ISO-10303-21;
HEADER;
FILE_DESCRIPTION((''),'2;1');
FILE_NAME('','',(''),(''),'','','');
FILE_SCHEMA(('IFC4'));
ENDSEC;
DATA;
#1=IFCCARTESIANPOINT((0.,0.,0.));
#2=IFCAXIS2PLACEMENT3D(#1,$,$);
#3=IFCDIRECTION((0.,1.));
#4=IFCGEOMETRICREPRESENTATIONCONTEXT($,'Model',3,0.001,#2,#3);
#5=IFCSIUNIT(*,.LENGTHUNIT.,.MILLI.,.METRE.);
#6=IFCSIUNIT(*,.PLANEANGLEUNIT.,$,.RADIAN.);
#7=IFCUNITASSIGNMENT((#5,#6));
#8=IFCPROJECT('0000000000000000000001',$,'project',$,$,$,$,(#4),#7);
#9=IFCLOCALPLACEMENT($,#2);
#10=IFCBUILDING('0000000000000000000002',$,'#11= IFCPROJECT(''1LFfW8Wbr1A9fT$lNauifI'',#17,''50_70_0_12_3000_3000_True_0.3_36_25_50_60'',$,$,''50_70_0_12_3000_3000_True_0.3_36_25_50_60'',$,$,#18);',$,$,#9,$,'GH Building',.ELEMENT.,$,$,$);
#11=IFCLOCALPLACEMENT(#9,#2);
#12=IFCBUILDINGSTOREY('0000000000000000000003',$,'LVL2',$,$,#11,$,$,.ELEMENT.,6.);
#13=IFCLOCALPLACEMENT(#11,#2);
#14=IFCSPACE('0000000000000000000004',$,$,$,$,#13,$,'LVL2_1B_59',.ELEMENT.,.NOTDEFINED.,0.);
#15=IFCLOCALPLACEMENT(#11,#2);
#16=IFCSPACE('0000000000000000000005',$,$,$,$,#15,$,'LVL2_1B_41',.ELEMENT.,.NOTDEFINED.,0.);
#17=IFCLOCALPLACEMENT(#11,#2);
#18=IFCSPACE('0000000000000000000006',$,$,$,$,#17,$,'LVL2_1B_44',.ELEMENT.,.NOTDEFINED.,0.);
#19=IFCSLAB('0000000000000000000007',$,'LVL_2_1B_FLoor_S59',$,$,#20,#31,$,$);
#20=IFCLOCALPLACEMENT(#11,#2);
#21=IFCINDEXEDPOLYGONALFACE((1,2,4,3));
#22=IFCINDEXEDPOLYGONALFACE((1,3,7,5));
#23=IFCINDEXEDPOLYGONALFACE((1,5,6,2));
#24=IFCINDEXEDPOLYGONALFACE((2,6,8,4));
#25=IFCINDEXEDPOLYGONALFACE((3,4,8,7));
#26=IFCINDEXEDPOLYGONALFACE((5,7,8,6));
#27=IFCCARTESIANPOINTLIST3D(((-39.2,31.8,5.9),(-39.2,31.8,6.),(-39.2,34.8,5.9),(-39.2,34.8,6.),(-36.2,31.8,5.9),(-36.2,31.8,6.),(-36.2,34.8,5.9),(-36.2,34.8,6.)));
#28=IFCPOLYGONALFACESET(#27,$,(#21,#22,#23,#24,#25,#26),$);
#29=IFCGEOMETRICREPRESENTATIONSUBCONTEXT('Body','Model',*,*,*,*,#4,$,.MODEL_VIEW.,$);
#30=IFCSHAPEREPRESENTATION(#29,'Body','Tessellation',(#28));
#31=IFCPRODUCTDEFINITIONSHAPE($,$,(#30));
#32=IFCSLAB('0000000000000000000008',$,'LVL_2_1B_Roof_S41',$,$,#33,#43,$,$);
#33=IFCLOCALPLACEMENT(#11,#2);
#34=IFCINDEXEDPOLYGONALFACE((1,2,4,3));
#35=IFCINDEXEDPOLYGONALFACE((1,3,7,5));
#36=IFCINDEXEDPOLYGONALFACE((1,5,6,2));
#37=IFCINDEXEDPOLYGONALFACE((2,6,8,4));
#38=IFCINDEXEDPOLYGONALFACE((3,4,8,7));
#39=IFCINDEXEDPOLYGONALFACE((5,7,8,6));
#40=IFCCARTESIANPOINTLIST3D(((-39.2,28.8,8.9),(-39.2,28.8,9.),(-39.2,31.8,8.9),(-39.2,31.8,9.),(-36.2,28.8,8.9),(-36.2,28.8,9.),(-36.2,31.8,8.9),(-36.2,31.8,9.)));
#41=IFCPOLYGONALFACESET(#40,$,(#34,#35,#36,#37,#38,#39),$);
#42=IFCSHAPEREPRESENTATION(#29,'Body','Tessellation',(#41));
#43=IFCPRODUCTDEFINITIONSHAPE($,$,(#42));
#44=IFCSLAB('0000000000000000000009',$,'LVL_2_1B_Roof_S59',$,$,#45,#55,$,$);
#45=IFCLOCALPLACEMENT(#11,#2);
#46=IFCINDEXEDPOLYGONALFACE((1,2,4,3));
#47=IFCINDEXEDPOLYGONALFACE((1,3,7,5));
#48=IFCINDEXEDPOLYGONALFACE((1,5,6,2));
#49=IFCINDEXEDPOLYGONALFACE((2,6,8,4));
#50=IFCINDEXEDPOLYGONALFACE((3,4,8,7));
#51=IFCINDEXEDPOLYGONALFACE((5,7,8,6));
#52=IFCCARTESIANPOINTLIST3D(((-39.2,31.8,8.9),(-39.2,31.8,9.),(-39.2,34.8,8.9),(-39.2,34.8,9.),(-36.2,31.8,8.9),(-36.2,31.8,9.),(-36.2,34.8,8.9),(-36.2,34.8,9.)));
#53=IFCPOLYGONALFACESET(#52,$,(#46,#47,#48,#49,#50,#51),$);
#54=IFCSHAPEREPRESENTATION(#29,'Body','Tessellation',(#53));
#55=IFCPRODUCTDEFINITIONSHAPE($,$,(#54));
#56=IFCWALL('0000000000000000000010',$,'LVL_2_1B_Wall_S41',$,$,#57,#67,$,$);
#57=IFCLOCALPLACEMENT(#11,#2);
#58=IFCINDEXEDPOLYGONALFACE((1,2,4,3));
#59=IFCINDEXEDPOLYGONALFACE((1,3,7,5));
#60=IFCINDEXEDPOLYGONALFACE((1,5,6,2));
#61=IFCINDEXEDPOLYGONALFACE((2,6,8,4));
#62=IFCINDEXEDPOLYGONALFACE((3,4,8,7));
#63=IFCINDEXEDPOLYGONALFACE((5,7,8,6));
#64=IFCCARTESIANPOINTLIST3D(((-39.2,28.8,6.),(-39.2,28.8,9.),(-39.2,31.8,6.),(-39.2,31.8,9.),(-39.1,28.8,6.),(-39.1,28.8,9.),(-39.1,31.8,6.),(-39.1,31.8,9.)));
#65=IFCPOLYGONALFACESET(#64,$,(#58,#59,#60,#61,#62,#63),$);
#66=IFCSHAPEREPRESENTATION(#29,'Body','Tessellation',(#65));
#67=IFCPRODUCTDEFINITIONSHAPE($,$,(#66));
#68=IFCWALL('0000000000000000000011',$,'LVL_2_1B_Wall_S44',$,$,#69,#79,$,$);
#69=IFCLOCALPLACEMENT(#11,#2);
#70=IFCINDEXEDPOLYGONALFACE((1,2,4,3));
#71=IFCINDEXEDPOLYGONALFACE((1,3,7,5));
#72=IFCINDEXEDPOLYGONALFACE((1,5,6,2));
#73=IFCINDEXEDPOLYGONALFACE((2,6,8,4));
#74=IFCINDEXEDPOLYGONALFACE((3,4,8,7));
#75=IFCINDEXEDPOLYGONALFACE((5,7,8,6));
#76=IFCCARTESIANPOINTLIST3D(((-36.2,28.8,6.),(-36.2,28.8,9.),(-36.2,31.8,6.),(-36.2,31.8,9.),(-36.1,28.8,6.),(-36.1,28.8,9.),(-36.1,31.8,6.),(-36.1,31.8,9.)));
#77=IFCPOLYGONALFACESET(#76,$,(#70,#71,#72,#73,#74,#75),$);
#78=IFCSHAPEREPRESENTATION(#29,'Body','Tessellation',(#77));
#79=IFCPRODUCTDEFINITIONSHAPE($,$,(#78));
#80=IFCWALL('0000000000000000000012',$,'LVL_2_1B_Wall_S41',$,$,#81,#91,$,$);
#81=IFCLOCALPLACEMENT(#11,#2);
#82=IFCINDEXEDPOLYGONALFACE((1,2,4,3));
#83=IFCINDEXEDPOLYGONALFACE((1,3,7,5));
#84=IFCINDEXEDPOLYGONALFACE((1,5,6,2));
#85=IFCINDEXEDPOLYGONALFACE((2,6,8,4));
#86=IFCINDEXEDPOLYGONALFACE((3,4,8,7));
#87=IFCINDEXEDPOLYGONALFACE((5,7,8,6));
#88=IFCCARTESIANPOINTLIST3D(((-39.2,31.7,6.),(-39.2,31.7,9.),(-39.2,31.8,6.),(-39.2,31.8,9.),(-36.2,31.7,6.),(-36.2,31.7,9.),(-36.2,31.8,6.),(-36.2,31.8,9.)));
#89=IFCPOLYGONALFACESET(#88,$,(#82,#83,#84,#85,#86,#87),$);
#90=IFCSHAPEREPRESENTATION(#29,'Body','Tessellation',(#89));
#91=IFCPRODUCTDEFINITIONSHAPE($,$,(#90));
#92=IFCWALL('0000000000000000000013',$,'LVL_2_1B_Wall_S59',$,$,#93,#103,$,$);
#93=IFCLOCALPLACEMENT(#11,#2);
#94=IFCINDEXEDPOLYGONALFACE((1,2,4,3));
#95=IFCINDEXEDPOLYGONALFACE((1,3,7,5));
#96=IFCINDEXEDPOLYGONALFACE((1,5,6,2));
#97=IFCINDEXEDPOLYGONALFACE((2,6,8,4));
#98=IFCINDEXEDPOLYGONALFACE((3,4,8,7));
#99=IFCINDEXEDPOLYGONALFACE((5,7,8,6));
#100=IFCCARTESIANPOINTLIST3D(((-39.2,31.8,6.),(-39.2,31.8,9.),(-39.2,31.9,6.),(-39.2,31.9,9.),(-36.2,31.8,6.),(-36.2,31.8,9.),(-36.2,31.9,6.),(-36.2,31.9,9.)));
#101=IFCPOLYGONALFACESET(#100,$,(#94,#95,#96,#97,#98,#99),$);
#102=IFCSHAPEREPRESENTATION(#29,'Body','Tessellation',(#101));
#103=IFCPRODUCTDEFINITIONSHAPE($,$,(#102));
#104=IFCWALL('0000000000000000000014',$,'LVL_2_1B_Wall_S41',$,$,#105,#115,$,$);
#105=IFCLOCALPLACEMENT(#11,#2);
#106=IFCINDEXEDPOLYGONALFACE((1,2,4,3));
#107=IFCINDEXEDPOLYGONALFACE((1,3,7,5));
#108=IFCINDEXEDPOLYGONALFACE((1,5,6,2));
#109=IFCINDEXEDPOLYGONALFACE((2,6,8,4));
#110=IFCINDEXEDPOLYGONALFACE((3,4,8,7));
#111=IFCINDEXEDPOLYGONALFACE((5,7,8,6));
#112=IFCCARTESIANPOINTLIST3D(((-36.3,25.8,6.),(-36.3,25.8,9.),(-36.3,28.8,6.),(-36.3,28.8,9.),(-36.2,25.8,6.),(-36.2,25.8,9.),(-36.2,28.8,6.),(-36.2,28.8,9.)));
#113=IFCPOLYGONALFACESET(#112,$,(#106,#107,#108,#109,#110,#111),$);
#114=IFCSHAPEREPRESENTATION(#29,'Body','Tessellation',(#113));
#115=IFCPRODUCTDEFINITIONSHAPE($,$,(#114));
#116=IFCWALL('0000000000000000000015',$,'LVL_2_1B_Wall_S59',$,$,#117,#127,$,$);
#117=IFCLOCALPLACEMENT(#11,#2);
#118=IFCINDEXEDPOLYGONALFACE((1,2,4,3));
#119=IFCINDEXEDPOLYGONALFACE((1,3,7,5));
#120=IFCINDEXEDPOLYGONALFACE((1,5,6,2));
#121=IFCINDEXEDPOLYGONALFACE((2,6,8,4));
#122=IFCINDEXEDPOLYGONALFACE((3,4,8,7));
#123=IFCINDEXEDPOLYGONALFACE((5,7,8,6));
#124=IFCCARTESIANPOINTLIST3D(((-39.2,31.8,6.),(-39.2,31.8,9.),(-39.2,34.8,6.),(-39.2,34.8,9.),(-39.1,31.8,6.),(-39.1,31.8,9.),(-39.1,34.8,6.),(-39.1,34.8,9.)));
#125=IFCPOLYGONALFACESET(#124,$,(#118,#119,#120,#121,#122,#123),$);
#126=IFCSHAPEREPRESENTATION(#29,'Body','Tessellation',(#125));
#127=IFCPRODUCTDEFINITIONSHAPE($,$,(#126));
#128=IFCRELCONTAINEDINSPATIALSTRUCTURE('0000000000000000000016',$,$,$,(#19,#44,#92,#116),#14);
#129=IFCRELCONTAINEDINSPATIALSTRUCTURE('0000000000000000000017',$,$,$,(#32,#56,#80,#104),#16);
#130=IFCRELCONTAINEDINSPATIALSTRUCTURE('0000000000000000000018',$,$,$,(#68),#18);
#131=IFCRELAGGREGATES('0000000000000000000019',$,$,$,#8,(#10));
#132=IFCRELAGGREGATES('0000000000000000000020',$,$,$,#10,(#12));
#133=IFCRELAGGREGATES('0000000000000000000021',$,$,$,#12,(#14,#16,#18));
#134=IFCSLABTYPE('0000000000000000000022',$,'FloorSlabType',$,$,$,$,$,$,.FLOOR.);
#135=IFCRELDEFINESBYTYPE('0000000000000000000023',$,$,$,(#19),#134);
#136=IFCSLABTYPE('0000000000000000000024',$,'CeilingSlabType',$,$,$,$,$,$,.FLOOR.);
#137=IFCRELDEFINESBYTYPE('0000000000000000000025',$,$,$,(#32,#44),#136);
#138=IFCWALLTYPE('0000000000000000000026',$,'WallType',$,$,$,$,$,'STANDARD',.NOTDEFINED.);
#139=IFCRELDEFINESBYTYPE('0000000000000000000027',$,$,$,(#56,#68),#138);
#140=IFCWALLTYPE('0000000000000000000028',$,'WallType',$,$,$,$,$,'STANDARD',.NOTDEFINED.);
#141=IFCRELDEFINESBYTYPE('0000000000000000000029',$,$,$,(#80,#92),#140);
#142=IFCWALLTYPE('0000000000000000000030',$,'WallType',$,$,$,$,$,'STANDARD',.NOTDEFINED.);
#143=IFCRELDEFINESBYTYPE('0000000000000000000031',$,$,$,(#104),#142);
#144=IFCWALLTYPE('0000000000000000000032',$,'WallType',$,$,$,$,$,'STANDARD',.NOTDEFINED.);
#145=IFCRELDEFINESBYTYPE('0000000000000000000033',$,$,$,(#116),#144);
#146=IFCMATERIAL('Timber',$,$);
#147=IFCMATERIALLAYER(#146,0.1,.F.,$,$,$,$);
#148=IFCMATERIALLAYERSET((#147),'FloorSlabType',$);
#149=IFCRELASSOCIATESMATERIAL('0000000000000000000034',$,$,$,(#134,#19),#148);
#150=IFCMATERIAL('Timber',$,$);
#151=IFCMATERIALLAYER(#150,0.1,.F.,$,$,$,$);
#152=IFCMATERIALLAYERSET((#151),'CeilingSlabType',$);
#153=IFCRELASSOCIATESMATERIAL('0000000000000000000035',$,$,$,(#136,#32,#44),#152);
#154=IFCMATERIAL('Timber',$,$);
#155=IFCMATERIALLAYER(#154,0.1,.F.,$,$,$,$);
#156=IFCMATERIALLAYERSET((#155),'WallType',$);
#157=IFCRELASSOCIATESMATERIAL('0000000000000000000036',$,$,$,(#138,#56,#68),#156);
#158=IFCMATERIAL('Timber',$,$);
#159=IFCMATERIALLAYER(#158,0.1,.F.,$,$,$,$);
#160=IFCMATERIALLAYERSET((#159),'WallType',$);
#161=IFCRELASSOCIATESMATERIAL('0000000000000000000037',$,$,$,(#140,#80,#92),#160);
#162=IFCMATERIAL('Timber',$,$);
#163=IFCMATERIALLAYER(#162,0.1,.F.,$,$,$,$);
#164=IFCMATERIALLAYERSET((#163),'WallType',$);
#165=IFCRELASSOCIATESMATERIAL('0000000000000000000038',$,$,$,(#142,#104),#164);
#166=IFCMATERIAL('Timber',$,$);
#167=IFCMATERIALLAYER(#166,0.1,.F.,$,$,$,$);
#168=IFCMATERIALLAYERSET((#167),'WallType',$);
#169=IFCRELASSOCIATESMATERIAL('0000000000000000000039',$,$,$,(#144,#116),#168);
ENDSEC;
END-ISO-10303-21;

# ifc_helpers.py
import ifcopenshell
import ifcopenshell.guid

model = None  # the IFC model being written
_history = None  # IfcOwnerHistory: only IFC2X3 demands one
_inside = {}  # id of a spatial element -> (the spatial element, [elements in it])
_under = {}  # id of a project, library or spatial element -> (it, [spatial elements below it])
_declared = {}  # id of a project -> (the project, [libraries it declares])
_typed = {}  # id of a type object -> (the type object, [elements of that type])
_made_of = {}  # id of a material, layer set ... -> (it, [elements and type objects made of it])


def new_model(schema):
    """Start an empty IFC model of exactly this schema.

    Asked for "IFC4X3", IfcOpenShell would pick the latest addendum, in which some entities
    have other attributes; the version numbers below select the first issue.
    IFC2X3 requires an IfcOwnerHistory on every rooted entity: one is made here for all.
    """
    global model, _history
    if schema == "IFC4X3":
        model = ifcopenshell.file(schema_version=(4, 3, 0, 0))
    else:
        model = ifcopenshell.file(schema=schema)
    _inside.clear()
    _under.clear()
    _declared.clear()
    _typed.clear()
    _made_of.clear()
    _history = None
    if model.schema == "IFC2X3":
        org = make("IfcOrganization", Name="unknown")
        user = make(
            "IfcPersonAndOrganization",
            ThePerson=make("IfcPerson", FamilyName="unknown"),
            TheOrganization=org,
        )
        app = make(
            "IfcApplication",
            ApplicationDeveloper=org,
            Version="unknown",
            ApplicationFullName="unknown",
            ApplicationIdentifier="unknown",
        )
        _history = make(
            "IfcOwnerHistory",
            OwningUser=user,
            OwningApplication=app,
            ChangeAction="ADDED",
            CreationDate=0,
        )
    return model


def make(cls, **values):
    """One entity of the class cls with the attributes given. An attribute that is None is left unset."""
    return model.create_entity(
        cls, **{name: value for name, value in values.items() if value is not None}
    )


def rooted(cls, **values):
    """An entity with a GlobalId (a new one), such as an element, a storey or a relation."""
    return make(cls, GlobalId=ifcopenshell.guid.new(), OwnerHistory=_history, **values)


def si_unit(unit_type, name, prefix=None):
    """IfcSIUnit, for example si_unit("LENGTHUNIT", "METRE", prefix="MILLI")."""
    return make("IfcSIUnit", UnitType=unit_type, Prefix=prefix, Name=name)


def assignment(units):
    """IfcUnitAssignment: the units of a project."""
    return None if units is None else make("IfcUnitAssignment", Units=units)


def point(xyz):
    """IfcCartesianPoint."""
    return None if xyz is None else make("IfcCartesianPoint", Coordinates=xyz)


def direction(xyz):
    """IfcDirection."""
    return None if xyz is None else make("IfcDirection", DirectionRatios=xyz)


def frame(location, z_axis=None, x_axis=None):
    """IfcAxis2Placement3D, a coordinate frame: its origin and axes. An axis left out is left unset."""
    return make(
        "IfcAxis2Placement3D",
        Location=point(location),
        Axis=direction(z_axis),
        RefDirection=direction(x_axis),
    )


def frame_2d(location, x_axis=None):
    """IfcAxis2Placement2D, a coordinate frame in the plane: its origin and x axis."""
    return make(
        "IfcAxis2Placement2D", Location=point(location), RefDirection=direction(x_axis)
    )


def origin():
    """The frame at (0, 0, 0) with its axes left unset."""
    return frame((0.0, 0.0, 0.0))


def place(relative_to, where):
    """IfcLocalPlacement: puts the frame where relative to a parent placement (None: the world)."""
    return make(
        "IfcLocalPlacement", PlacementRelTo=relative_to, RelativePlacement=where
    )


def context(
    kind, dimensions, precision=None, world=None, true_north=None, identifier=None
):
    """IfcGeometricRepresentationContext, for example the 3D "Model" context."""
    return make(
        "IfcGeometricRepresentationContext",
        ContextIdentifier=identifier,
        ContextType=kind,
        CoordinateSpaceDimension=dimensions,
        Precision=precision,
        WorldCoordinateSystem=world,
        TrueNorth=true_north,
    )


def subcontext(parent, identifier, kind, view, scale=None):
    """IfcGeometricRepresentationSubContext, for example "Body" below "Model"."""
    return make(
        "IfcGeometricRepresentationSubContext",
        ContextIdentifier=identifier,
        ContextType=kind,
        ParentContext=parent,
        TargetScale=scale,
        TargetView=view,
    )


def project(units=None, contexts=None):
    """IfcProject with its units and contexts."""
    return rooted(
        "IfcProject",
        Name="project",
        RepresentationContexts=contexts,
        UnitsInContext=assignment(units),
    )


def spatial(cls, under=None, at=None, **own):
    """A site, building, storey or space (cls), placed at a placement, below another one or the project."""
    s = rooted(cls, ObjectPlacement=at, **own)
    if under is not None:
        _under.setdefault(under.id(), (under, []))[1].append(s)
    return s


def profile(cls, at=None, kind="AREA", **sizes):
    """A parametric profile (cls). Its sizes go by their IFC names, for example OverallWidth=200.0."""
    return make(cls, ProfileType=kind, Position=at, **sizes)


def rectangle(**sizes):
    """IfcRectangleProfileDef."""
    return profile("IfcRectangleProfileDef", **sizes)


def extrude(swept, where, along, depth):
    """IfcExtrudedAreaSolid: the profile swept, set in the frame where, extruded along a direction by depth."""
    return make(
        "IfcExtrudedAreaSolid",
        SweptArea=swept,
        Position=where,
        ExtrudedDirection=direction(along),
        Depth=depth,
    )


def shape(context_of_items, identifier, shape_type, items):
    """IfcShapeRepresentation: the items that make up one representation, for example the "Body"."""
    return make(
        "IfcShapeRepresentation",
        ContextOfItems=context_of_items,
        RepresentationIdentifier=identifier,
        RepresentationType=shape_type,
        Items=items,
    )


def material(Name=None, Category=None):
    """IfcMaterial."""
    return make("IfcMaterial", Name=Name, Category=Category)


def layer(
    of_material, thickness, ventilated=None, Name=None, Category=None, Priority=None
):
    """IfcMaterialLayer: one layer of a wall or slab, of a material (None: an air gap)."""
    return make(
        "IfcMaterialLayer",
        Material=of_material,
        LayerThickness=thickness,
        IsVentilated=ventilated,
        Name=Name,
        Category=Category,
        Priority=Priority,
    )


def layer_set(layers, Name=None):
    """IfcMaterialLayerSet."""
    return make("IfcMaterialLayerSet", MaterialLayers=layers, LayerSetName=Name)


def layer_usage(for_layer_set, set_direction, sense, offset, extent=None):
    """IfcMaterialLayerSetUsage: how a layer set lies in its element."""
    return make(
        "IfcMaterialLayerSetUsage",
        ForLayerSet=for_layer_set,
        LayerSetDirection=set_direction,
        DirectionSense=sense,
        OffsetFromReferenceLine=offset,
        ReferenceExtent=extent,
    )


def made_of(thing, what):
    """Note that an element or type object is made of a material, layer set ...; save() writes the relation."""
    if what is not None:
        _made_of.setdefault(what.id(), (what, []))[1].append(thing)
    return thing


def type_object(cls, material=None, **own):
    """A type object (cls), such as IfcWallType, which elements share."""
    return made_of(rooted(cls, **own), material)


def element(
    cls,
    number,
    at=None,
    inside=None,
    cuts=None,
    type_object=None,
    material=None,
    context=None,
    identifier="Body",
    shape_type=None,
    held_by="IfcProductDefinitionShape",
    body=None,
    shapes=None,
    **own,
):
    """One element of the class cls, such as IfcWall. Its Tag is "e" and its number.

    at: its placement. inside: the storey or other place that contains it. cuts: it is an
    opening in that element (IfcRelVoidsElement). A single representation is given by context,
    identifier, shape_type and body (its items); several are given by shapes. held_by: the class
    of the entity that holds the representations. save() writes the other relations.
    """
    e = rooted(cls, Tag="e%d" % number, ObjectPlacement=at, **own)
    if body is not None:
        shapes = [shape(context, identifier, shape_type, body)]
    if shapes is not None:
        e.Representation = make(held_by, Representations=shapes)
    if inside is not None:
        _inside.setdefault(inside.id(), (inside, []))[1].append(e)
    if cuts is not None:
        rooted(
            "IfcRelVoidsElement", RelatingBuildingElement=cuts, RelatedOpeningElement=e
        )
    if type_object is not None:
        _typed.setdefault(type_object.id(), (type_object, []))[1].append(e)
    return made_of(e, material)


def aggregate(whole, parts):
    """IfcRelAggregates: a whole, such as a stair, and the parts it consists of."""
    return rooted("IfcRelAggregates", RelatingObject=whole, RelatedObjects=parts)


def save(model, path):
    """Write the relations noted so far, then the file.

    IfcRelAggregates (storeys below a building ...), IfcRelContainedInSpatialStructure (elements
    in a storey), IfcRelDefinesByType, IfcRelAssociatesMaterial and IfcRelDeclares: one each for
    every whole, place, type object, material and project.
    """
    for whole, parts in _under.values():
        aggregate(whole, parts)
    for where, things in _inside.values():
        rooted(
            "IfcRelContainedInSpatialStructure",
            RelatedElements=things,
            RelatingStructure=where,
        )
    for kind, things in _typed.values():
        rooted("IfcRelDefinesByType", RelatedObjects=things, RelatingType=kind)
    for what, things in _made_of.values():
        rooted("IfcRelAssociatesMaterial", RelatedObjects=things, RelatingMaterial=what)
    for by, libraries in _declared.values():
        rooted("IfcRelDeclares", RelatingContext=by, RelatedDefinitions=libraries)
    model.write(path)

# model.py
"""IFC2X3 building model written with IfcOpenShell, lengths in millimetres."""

from ifc_helpers import new_model, si_unit, direction, frame, frame_2d, origin, place, context, subcontext, project, spatial, rectangle, extrude, material, layer, layer_set, layer_usage, type_object, element, save


model = new_model("IFC2X3")

# Units and contexts
model_context = context("Model", 3, precision=0.001, world=origin(), true_north=direction((0.0, 1.0)))
body_context = subcontext(model_context, "Body", "Model", "MODEL_VIEW")
ifc_project = project(units=[si_unit("LENGTHUNIT", "METRE", prefix="MILLI"), si_unit("PLANEANGLEUNIT", "RADIAN")], contexts=[model_context])

# Building, storey
building_placement = place(None, origin())
building = spatial("IfcBuilding", under=ifc_project, at=building_placement, Name="#11= IFCPROJECT('1LFfW8Wbr1A9fT$lNauifI',#17,'50_70_0_12_3000_3000_True_0.3_36_25_50_60',$,$,'50_70_0_12_3000_3000_True_0.3_36_25_50_60',$,$,#18);", LongName="GH Building", CompositionType="ELEMENT")
storey_placement = place(building_placement, origin())
storey = spatial("IfcBuildingStorey", under=building, at=storey_placement, Name="LVL2", CompositionType="ELEMENT", Elevation=6.0)

# Shared definitions
space_1_placement = place(storey_placement, origin())
space_1 = spatial("IfcSpace", under=storey, at=space_1_placement, LongName="LVL2_1B_59", CompositionType="ELEMENT", InteriorOrExteriorSpace="NOTDEFINED", ElevationWithFlooring=0.0)

# Slab
ifc_material_1 = material(Name="Timber")
ifc_layer_1 = layer(ifc_material_1, 0.1, ventilated=False)
ifc_layer_set_1 = layer_set([ifc_layer_1], Name="FloorSlabType")
ifc_layer_usage_1 = layer_usage(ifc_layer_set_1, "AXIS3", "NEGATIVE", -0.1)
slab_type_1 = type_object("IfcSlabType", Name="FloorSlabType", PredefinedType="FLOOR", material=ifc_layer_set_1)
slab_1_placement = place(space_1_placement, frame((-39.2, 34.8, 5.9), z_axis=(0.0, 0.0, 1.0), x_axis=(0.0, -1.0, 0.0)))
element("IfcSlab", 1, at=slab_1_placement, inside=space_1, type_object=slab_type_1, material=ifc_layer_usage_1, Name="LVL_2_1B_FLoor_S59", context=body_context, shape_type="SweptSolid", body=[
    extrude(rectangle(XDim=3.0, YDim=3.0, at=frame_2d((1.5, 1.5))), origin(), (0.0, 0.0, 1.0), 0.1),
])

# Shared definitions
space_2_placement = place(storey_placement, origin())
space_2 = spatial("IfcSpace", under=storey, at=space_2_placement, LongName="LVL2_1B_41", CompositionType="ELEMENT", InteriorOrExteriorSpace="NOTDEFINED", ElevationWithFlooring=0.0)

# Slabs
ifc_material_2 = material(Name="Timber")
ifc_layer_2 = layer(ifc_material_2, 0.1, ventilated=False)
ifc_layer_set_2 = layer_set([ifc_layer_2], Name="CeilingSlabType")
ifc_layer_usage_2 = layer_usage(ifc_layer_set_2, "AXIS3", "NEGATIVE", -0.1)
slab_type_2 = type_object("IfcSlabType", Name="CeilingSlabType", PredefinedType="FLOOR", material=ifc_layer_set_2)
slab_2_placement = place(space_2_placement, frame((-36.2, 28.8, 8.9), z_axis=(0.0, 0.0, 1.0), x_axis=(0.0, 1.0, 0.0)))
element("IfcSlab", 2, at=slab_2_placement, inside=space_2, type_object=slab_type_2, material=ifc_layer_usage_2, Name="LVL_2_1B_Roof_S41", context=body_context, shape_type="SweptSolid", body=[
    extrude(rectangle(XDim=3.0, YDim=3.0, at=frame_2d((1.5, 1.5))), origin(), (0.0, 0.0, 1.0), 0.1),
])
ifc_layer_usage_3 = layer_usage(ifc_layer_set_2, "AXIS3", "NEGATIVE", -0.1)
slab_3_placement = place(space_1_placement, frame((-39.2, 34.8, 8.9), z_axis=(0.0, 0.0, 1.0), x_axis=(0.0, -1.0, 0.0)))
element("IfcSlab", 3, at=slab_3_placement, inside=space_1, type_object=slab_type_2, material=ifc_layer_usage_3, Name="LVL_2_1B_Roof_S59", context=body_context, shape_type="SweptSolid", body=[
    extrude(rectangle(XDim=3.0, YDim=3.0, at=frame_2d((1.5, 1.5))), origin(), (0.0, 0.0, 1.0), 0.1),
])

# Shared definitions
space_3_placement = place(storey_placement, origin())
space_3 = spatial("IfcSpace", under=storey, at=space_3_placement, LongName="LVL2_1B_44", CompositionType="ELEMENT", InteriorOrExteriorSpace="NOTDEFINED", ElevationWithFlooring=0.0)

# Walls
ifc_material_3 = material(Name="Timber")
ifc_layer_3 = layer(ifc_material_3, 0.1, ventilated=False)
ifc_layer_set_3 = layer_set([ifc_layer_3], Name="WallType")
ifc_layer_usage_4 = layer_usage(ifc_layer_set_3, "AXIS2", "NEGATIVE", 0.0)
wall_type_1 = type_object("IfcWallType", Name="WallType", ElementType="STANDARD", PredefinedType="NOTDEFINED", material=ifc_layer_set_3)
wall_1_placement = place(space_2_placement, frame((-39.2, 28.8, 6.0), z_axis=(0.0, 0.0, 1.0), x_axis=(0.0, 1.0, 0.0)))
element("IfcWall", 4, at=wall_1_placement, inside=space_2, type_object=wall_type_1, material=ifc_layer_usage_4, Name="LVL_2_1B_Wall_S41", context=body_context, shape_type="SweptSolid", body=[
    extrude(rectangle(XDim=3.0, YDim=0.1, at=frame_2d((1.5, -0.1))), origin(), (0.0, 0.0, 1.0), 3.0),
])
ifc_layer_usage_5 = layer_usage(ifc_layer_set_3, "AXIS2", "NEGATIVE", 0.0)
wall_2_placement = place(space_3_placement, frame((-36.2, 28.8, 6.0), z_axis=(0.0, 0.0, 1.0), x_axis=(0.0, 1.0, 0.0)))
element("IfcWall", 5, at=wall_2_placement, inside=space_3, type_object=wall_type_1, material=ifc_layer_usage_5, Name="LVL_2_1B_Wall_S44", context=body_context, shape_type="SweptSolid", body=[
    extrude(rectangle(XDim=3.0, YDim=0.1, at=frame_2d((1.5, -0.1))), origin(), (0.0, 0.0, 1.0), 3.0),
])
ifc_material_4 = material(Name="Timber")
ifc_layer_4 = layer(ifc_material_4, 0.1, ventilated=False)
ifc_layer_set_4 = layer_set([ifc_layer_4], Name="WallType")
ifc_layer_usage_6 = layer_usage(ifc_layer_set_4, "AXIS2", "NEGATIVE", 0.0)
wall_type_2 = type_object("IfcWallType", Name="WallType", ElementType="STANDARD", PredefinedType="NOTDEFINED", material=ifc_layer_set_4)
wall_3_placement = place(space_2_placement, frame((-39.2, 31.8, 6.0)))
element("IfcWall", 6, at=wall_3_placement, inside=space_2, type_object=wall_type_2, material=ifc_layer_usage_6, Name="LVL_2_1B_Wall_S41", context=body_context, shape_type="SweptSolid", body=[
    extrude(rectangle(XDim=3.0, YDim=0.1, at=frame_2d((1.5, -0.1))), origin(), (0.0, 0.0, 1.0), 3.0),
])
ifc_layer_usage_7 = layer_usage(ifc_layer_set_4, "AXIS2", "NEGATIVE", 0.0)
wall_4_placement = place(space_1_placement, frame((-36.2, 31.8, 6.0), z_axis=(0.0, 0.0, 1.0), x_axis=(-1.0, 0.0, 0.0)))
element("IfcWall", 7, at=wall_4_placement, inside=space_1, type_object=wall_type_2, material=ifc_layer_usage_7, Name="LVL_2_1B_Wall_S59", context=body_context, shape_type="SweptSolid", body=[
    extrude(rectangle(XDim=3.0, YDim=0.1, at=frame_2d((1.5, -0.1))), origin(), (0.0, 0.0, 1.0), 3.0),
])
ifc_material_5 = material(Name="Timber")
ifc_layer_5 = layer(ifc_material_5, 0.1, ventilated=False)
ifc_layer_set_5 = layer_set([ifc_layer_5], Name="WallType")
ifc_layer_usage_8 = layer_usage(ifc_layer_set_5, "AXIS2", "NEGATIVE", 0.0)
wall_type_3 = type_object("IfcWallType", Name="WallType", ElementType="STANDARD", PredefinedType="NOTDEFINED", material=ifc_layer_set_5)
wall_5_placement = place(space_2_placement, frame((-36.2, 28.8, 6.0), z_axis=(0.0, 0.0, 1.0), x_axis=(0.0, -1.0, 0.0)))
element("IfcWall", 8, at=wall_5_placement, inside=space_2, type_object=wall_type_3, material=ifc_layer_usage_8, Name="LVL_2_1B_Wall_S41", context=body_context, shape_type="SweptSolid", body=[
    extrude(rectangle(XDim=3.0, YDim=0.1, at=frame_2d((1.5, -0.1))), origin(), (0.0, 0.0, 1.0), 3.0),
])
ifc_material_6 = material(Name="Timber")
ifc_layer_6 = layer(ifc_material_6, 0.1, ventilated=False)
ifc_layer_set_6 = layer_set([ifc_layer_6], Name="WallType")
ifc_layer_usage_9 = layer_usage(ifc_layer_set_6, "AXIS2", "NEGATIVE", 0.0)
wall_type_4 = type_object("IfcWallType", Name="WallType", ElementType="STANDARD", PredefinedType="NOTDEFINED", material=ifc_layer_set_6)
wall_6_placement = place(space_1_placement, frame((-39.2, 31.8, 6.0), z_axis=(0.0, 0.0, 1.0), x_axis=(0.0, 1.0, 0.0)))
element("IfcWall", 9, at=wall_6_placement, inside=space_1, type_object=wall_type_4, material=ifc_layer_usage_9, Name="LVL_2_1B_Wall_S59", context=body_context, shape_type="SweptSolid", body=[
    extrude(rectangle(XDim=3.0, YDim=0.1, at=frame_2d((1.5, -0.1))), origin(), (0.0, 0.0, 1.0), 3.0),
])

save(model, "model.ifc")
